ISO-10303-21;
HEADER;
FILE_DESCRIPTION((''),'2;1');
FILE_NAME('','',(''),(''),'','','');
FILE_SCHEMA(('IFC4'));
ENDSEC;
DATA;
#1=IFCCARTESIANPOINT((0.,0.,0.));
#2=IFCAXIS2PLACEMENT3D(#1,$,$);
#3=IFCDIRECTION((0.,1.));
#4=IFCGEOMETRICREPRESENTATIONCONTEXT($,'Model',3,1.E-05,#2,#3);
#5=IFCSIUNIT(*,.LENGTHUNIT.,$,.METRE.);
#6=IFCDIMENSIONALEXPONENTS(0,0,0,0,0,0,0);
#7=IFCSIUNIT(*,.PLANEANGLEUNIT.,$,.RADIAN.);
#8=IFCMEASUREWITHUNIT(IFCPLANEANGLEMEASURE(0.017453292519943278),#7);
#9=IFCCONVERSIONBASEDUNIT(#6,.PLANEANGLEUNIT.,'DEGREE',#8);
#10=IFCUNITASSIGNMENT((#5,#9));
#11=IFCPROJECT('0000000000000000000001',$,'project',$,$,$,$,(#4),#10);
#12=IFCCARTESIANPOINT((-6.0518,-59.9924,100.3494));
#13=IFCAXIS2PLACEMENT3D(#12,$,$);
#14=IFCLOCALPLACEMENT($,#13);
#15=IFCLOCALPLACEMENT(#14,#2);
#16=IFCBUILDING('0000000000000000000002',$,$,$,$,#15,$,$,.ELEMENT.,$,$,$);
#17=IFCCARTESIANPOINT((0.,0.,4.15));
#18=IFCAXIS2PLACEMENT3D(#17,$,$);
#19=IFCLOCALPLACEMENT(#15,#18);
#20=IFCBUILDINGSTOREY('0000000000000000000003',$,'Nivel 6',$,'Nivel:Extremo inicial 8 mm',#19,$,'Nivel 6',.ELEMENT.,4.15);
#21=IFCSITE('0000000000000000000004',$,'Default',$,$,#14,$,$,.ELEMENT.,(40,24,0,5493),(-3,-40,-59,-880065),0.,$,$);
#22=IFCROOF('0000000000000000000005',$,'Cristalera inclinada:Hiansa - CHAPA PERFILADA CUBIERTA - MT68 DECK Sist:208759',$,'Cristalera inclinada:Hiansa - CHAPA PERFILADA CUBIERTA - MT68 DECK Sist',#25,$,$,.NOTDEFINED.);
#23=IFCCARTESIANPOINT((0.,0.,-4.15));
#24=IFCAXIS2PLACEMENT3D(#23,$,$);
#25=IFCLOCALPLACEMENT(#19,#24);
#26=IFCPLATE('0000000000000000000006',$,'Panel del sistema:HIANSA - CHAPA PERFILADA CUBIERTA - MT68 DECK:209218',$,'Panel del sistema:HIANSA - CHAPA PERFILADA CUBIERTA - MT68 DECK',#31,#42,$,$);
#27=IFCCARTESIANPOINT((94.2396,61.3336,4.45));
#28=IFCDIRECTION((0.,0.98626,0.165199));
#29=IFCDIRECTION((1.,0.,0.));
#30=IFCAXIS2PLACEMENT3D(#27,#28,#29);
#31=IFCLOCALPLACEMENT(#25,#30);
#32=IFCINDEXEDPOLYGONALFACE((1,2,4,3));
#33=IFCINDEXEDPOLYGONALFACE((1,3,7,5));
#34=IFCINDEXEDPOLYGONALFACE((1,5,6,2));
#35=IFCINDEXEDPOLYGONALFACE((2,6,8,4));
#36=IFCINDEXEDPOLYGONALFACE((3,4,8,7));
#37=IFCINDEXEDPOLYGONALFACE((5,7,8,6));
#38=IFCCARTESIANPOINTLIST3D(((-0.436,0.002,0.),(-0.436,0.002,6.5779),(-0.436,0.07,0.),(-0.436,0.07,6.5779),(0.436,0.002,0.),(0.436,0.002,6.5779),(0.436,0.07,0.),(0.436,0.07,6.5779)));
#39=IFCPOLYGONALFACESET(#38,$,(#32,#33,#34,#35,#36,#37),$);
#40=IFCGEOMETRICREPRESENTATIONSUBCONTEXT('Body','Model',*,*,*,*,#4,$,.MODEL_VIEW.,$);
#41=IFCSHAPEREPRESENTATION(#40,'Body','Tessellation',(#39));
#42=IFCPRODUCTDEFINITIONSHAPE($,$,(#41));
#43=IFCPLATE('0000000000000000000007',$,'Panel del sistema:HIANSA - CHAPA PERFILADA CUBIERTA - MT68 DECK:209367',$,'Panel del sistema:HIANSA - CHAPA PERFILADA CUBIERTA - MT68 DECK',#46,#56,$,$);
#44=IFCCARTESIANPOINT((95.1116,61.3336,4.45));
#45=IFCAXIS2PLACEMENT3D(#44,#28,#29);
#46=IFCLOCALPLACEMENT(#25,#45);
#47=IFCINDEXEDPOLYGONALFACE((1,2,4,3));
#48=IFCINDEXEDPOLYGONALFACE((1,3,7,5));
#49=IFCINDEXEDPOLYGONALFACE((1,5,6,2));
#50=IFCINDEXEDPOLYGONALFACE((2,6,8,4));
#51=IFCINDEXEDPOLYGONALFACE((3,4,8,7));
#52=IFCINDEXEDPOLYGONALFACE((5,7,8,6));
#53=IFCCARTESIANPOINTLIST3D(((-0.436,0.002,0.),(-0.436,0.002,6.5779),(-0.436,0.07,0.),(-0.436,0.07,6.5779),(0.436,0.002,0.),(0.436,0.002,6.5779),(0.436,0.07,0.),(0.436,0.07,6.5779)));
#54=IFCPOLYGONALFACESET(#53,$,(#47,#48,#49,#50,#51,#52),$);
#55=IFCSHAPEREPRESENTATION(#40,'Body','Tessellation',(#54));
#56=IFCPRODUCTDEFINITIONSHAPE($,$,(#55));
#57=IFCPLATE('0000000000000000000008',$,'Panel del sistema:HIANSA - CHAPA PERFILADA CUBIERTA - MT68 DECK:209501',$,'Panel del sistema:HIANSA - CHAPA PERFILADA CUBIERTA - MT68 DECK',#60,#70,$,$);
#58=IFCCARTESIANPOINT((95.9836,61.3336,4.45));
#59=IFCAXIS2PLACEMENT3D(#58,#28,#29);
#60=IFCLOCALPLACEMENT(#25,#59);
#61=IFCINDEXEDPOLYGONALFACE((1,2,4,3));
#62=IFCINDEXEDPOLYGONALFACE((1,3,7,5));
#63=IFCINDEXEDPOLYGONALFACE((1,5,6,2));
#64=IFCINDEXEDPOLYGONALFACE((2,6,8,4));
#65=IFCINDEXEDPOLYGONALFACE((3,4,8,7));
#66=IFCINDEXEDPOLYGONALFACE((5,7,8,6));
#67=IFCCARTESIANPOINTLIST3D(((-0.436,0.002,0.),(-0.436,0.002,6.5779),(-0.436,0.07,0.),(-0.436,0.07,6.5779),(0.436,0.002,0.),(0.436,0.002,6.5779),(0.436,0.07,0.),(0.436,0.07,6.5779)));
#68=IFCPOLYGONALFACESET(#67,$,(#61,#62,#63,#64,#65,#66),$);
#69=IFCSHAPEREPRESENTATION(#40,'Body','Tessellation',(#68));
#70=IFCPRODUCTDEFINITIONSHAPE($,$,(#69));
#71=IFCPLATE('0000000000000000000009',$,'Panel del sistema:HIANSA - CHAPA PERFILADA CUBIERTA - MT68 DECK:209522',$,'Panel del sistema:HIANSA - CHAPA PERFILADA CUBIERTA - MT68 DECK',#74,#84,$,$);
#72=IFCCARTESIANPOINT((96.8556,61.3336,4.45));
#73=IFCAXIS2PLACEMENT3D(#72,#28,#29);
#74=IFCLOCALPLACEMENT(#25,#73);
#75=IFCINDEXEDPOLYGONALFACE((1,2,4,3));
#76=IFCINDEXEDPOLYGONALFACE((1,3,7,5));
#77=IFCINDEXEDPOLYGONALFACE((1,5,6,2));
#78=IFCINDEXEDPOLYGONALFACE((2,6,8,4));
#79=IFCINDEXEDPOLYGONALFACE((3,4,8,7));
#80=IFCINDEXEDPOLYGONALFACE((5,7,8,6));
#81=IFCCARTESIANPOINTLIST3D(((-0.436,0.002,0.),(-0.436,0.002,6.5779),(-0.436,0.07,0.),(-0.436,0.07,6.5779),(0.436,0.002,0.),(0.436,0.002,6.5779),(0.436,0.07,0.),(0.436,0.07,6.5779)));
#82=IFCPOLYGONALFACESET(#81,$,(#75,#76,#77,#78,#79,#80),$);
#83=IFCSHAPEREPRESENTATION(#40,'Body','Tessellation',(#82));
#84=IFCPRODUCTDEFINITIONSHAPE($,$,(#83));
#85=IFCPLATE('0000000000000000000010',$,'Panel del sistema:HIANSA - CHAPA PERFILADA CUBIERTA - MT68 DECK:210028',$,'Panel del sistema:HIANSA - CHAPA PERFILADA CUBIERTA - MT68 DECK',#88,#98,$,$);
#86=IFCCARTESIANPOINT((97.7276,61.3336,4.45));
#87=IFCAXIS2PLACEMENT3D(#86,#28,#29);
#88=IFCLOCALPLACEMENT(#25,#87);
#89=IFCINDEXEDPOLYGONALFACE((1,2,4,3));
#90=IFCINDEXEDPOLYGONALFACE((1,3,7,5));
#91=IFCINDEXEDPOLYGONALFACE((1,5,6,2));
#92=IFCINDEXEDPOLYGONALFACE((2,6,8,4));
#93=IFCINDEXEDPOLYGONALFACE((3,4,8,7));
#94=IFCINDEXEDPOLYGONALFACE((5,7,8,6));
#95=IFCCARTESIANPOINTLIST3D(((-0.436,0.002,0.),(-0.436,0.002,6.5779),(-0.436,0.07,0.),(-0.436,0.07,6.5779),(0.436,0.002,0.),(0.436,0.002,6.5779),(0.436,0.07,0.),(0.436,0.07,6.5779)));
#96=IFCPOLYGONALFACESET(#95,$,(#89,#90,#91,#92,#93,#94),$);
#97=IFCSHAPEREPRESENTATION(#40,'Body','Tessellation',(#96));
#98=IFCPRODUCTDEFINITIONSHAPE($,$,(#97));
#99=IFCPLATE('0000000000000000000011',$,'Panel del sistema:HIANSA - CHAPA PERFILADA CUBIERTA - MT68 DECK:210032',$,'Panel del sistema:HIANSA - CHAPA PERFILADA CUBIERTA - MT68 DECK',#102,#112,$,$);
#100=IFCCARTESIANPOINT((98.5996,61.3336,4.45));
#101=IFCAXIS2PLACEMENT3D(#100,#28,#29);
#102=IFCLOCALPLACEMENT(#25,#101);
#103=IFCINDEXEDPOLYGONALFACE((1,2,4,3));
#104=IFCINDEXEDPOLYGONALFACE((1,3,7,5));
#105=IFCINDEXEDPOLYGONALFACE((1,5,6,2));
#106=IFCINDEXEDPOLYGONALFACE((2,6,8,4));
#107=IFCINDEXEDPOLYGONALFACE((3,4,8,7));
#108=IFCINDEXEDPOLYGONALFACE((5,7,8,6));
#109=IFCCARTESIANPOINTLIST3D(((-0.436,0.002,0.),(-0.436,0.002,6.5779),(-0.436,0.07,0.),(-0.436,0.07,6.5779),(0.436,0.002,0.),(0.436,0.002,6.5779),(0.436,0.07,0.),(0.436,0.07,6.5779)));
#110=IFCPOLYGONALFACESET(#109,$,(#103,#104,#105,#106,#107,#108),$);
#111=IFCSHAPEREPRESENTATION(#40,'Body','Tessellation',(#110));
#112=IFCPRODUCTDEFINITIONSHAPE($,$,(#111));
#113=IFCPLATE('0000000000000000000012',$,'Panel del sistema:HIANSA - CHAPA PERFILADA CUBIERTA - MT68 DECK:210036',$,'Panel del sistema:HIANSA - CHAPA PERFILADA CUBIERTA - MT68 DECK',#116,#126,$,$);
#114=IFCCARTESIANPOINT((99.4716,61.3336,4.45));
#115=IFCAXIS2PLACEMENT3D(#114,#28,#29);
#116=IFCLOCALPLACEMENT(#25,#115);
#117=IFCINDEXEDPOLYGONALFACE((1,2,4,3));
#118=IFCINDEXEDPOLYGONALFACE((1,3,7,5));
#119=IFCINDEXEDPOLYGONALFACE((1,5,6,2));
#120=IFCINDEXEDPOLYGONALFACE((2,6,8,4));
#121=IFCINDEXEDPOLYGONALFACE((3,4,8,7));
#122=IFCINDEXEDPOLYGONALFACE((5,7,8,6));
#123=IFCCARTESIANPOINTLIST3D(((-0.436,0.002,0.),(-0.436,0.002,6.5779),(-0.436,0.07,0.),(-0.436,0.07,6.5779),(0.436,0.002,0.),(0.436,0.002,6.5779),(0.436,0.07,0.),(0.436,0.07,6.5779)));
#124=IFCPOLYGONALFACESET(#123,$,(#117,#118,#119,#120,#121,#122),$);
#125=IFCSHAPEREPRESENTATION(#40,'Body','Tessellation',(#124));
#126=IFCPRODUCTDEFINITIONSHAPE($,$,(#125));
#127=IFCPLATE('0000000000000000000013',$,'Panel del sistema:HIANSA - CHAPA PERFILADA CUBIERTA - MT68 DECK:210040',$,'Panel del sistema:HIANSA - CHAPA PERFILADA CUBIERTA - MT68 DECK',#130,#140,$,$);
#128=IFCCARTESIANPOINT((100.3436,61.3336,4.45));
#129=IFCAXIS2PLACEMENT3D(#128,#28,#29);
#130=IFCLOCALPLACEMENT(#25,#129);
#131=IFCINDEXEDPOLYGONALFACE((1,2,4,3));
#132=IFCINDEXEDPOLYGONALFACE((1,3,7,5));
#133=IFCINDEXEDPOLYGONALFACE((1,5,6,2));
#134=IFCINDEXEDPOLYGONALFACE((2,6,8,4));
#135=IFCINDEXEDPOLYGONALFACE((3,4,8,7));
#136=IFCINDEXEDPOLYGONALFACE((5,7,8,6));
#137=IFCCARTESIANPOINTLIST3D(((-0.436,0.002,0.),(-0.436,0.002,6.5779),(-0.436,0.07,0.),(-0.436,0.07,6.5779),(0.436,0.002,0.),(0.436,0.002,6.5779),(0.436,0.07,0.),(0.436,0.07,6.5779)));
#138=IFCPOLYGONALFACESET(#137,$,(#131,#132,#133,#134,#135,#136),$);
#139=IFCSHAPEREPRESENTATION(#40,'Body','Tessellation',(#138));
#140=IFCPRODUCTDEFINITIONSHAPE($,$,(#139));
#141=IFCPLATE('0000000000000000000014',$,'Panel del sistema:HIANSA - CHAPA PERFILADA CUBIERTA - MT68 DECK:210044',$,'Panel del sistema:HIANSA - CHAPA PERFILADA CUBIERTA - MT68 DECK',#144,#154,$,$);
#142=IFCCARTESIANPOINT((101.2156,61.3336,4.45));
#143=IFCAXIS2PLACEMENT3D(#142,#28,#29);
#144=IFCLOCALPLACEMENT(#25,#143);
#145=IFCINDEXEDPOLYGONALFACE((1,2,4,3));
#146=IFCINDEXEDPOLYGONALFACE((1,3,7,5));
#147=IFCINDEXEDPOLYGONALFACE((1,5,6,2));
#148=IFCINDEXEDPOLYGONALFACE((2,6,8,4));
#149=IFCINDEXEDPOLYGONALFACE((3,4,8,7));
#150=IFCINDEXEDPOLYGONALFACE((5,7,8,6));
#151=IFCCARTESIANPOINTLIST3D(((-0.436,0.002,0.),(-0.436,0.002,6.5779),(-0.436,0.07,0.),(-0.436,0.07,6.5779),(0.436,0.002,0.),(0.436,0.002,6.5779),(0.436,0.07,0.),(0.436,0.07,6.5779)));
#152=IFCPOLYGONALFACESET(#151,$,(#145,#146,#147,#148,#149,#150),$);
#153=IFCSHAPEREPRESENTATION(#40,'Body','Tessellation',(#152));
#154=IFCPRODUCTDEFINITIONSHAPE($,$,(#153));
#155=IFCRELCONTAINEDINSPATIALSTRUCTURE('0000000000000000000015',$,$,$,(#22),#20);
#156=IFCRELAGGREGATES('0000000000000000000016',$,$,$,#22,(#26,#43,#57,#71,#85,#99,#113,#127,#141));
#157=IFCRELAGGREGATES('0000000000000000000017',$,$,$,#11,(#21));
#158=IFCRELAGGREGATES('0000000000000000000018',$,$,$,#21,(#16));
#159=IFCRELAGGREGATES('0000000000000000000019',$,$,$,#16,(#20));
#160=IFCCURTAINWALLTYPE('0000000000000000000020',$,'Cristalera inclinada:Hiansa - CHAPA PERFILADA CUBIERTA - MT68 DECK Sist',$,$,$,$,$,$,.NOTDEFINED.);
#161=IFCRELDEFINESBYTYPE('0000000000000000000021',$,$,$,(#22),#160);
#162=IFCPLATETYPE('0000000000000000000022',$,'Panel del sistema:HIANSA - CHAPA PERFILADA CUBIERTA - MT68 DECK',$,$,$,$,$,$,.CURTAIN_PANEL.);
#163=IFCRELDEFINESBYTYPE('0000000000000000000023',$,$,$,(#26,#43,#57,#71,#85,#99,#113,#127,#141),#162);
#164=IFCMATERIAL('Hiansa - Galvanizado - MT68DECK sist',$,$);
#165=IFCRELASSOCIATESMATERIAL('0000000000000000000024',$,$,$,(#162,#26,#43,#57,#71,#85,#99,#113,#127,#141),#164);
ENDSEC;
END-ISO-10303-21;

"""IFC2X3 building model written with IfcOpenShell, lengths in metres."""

from ifc_helpers import new_model, entity, si_unit, converted_unit, direction, frame, origin, origin_2d_with_axis, place, context, subcontext, project, spatial, rectangle, extrude, source, transform, mapped, material, type_object, type_shapes, element, aggregate, save


model = new_model("IFC2X3")

# Units and contexts
model_context = context("Model", 3, precision=1e-05, world=origin(), true_north=direction((0.0, 1.0)))
body_context = subcontext(model_context, "Body", "Model", "MODEL_VIEW")
ifc_project = project(units=[si_unit("LENGTHUNIT", "METRE"), converted_unit("PLANEANGLEUNIT", "DEGREE", entity("IfcPlaneAngleMeasure", 0.017453292519943278), si_unit("PLANEANGLEUNIT", "RADIAN"), dimensions=[0, 0, 0, 0, 0, 0, 0])], contexts=[model_context])

# Site, building, storey
site_placement = place(None, frame((-6.0518, -59.9924, 100.3494)))
site = spatial("IfcSite", under=ifc_project, at=site_placement, Name="Default", CompositionType="ELEMENT", RefLatitude=(40, 24, 0, 5493), RefLongitude=(-3, -40, -59, -880065), RefElevation=0.0)
building_placement = place(site_placement, origin())
building = spatial("IfcBuilding", under=site, at=building_placement, CompositionType="ELEMENT")
storey_placement = place(building_placement, frame((0.0, 0.0, 4.15)))
storey = spatial("IfcBuildingStorey", under=building, at=storey_placement, Name="Nivel 6", ObjectType="Nivel:Extremo inicial 8 mm", LongName="Nivel 6", CompositionType="ELEMENT", Elevation=4.15)

# Roof, plates
curtain_wall_type = type_object("IfcCurtainWallType", Name="Cristalera inclinada:Hiansa - CHAPA PERFILADA CUBIERTA - MT68 DECK Sist", PredefinedType="NOTDEFINED")
roof_placement = place(storey_placement, frame((0.0, 0.0, -4.15)))
roof = element("IfcRoof", 1, at=roof_placement, inside=storey, type_object=curtain_wall_type, Name="Cristalera inclinada:Hiansa - CHAPA PERFILADA CUBIERTA - MT68 DECK Sist:208759", ObjectType="Cristalera inclinada:Hiansa - CHAPA PERFILADA CUBIERTA - MT68 DECK Sist", ShapeType="NOTDEFINED")
ifc_material_1 = material(Name="Hiansa - Galvanizado - MT68DECK sist")
plate_type_1 = type_object("IfcPlateType", Name="Panel del sistema:HIANSA - CHAPA PERFILADA CUBIERTA - MT68 DECK", PredefinedType="CURTAIN_PANEL", material=ifc_material_1)
shared_shape_1 = source(origin(), body_context, "Body", "SweptSolid", [
    extrude(rectangle(XDim=0.068, YDim=0.872, at=origin_2d_with_axis()), frame((0.0, 0.036, 0.0), z_axis=(0.0, 0.0, 1.0), x_axis=(0.0, 1.0, 0.0)), (0.0, 0.0, 1.0), 6.5779),
])
type_shapes(plate_type_1, [shared_shape_1])
plate_1_placement = place(roof_placement, frame((94.2396, 61.3336, 4.45), z_axis=(0.0, 0.98626, 0.165199), x_axis=(1.0, 0.0, 0.0)))
plate_1 = element("IfcPlate", 2, at=plate_1_placement, type_object=plate_type_1, material=ifc_material_1, Name="Panel del sistema:HIANSA - CHAPA PERFILADA CUBIERTA - MT68 DECK:209218", ObjectType="Panel del sistema:HIANSA - CHAPA PERFILADA CUBIERTA - MT68 DECK", context=body_context, shape_type="MappedRepresentation", body=[
    mapped(shared_shape_1, transform((0.0, 0.0, 0.0), scale=1.0)),
])
plate_2_placement = place(roof_placement, frame((95.1116, 61.3336, 4.45), z_axis=(0.0, 0.98626, 0.165199), x_axis=(1.0, 0.0, 0.0)))
plate_2 = element("IfcPlate", 3, at=plate_2_placement, type_object=plate_type_1, material=ifc_material_1, Name="Panel del sistema:HIANSA - CHAPA PERFILADA CUBIERTA - MT68 DECK:209367", ObjectType="Panel del sistema:HIANSA - CHAPA PERFILADA CUBIERTA - MT68 DECK", context=body_context, shape_type="MappedRepresentation", body=[
    mapped(shared_shape_1, transform((0.0, 0.0, 0.0), scale=1.0)),
])
plate_3_placement = place(roof_placement, frame((95.9836, 61.3336, 4.45), z_axis=(0.0, 0.98626, 0.165199), x_axis=(1.0, 0.0, 0.0)))
plate_3 = element("IfcPlate", 4, at=plate_3_placement, type_object=plate_type_1, material=ifc_material_1, Name="Panel del sistema:HIANSA - CHAPA PERFILADA CUBIERTA - MT68 DECK:209501", ObjectType="Panel del sistema:HIANSA - CHAPA PERFILADA CUBIERTA - MT68 DECK", context=body_context, shape_type="MappedRepresentation", body=[
    mapped(shared_shape_1, transform((0.0, 0.0, 0.0), scale=1.0)),
])
plate_4_placement = place(roof_placement, frame((96.8556, 61.3336, 4.45), z_axis=(0.0, 0.98626, 0.165199), x_axis=(1.0, 0.0, 0.0)))
plate_4 = element("IfcPlate", 5, at=plate_4_placement, type_object=plate_type_1, material=ifc_material_1, Name="Panel del sistema:HIANSA - CHAPA PERFILADA CUBIERTA - MT68 DECK:209522", ObjectType="Panel del sistema:HIANSA - CHAPA PERFILADA CUBIERTA - MT68 DECK", context=body_context, shape_type="MappedRepresentation", body=[
    mapped(shared_shape_1, transform((0.0, 0.0, 0.0), scale=1.0)),
])
plate_5_placement = place(roof_placement, frame((97.7276, 61.3336, 4.45), z_axis=(0.0, 0.98626, 0.165199), x_axis=(1.0, 0.0, 0.0)))
plate_5 = element("IfcPlate", 6, at=plate_5_placement, type_object=plate_type_1, material=ifc_material_1, Name="Panel del sistema:HIANSA - CHAPA PERFILADA CUBIERTA - MT68 DECK:210028", ObjectType="Panel del sistema:HIANSA - CHAPA PERFILADA CUBIERTA - MT68 DECK", context=body_context, shape_type="MappedRepresentation", body=[
    mapped(shared_shape_1, transform((0.0, 0.0, 0.0), scale=1.0)),
])
plate_6_placement = place(roof_placement, frame((98.5996, 61.3336, 4.45), z_axis=(0.0, 0.98626, 0.165199), x_axis=(1.0, 0.0, 0.0)))
plate_6 = element("IfcPlate", 7, at=plate_6_placement, type_object=plate_type_1, material=ifc_material_1, Name="Panel del sistema:HIANSA - CHAPA PERFILADA CUBIERTA - MT68 DECK:210032", ObjectType="Panel del sistema:HIANSA - CHAPA PERFILADA CUBIERTA - MT68 DECK", context=body_context, shape_type="MappedRepresentation", body=[
    mapped(shared_shape_1, transform((0.0, 0.0, 0.0), scale=1.0)),
])
plate_7_placement = place(roof_placement, frame((99.4716, 61.3336, 4.45), z_axis=(0.0, 0.98626, 0.165199), x_axis=(1.0, 0.0, 0.0)))
plate_7 = element("IfcPlate", 8, at=plate_7_placement, type_object=plate_type_1, material=ifc_material_1, Name="Panel del sistema:HIANSA - CHAPA PERFILADA CUBIERTA - MT68 DECK:210036", ObjectType="Panel del sistema:HIANSA - CHAPA PERFILADA CUBIERTA - MT68 DECK", context=body_context, shape_type="MappedRepresentation", body=[
    mapped(shared_shape_1, transform((0.0, 0.0, 0.0), scale=1.0)),
])
plate_8_placement = place(roof_placement, frame((100.3436, 61.3336, 4.45), z_axis=(0.0, 0.98626, 0.165199), x_axis=(1.0, 0.0, 0.0)))
plate_8 = element("IfcPlate", 9, at=plate_8_placement, type_object=plate_type_1, material=ifc_material_1, Name="Panel del sistema:HIANSA - CHAPA PERFILADA CUBIERTA - MT68 DECK:210040", ObjectType="Panel del sistema:HIANSA - CHAPA PERFILADA CUBIERTA - MT68 DECK", context=body_context, shape_type="MappedRepresentation", body=[
    mapped(shared_shape_1, transform((0.0, 0.0, 0.0), scale=1.0)),
])
plate_9_placement = place(roof_placement, frame((101.2156, 61.3336, 4.45), z_axis=(0.0, 0.98626, 0.165199), x_axis=(1.0, 0.0, 0.0)))
plate_9 = element("IfcPlate", 10, at=plate_9_placement, type_object=plate_type_1, material=ifc_material_1, Name="Panel del sistema:HIANSA - CHAPA PERFILADA CUBIERTA - MT68 DECK:210044", ObjectType="Panel del sistema:HIANSA - CHAPA PERFILADA CUBIERTA - MT68 DECK", context=body_context, shape_type="MappedRepresentation", body=[
    mapped(shared_shape_1, transform((0.0, 0.0, 0.0), scale=1.0)),
])
aggregate(roof, [plate_1, plate_2, plate_3, plate_4, plate_5, plate_6, plate_7, plate_8, plate_9])

save(model, "model.ifc")
